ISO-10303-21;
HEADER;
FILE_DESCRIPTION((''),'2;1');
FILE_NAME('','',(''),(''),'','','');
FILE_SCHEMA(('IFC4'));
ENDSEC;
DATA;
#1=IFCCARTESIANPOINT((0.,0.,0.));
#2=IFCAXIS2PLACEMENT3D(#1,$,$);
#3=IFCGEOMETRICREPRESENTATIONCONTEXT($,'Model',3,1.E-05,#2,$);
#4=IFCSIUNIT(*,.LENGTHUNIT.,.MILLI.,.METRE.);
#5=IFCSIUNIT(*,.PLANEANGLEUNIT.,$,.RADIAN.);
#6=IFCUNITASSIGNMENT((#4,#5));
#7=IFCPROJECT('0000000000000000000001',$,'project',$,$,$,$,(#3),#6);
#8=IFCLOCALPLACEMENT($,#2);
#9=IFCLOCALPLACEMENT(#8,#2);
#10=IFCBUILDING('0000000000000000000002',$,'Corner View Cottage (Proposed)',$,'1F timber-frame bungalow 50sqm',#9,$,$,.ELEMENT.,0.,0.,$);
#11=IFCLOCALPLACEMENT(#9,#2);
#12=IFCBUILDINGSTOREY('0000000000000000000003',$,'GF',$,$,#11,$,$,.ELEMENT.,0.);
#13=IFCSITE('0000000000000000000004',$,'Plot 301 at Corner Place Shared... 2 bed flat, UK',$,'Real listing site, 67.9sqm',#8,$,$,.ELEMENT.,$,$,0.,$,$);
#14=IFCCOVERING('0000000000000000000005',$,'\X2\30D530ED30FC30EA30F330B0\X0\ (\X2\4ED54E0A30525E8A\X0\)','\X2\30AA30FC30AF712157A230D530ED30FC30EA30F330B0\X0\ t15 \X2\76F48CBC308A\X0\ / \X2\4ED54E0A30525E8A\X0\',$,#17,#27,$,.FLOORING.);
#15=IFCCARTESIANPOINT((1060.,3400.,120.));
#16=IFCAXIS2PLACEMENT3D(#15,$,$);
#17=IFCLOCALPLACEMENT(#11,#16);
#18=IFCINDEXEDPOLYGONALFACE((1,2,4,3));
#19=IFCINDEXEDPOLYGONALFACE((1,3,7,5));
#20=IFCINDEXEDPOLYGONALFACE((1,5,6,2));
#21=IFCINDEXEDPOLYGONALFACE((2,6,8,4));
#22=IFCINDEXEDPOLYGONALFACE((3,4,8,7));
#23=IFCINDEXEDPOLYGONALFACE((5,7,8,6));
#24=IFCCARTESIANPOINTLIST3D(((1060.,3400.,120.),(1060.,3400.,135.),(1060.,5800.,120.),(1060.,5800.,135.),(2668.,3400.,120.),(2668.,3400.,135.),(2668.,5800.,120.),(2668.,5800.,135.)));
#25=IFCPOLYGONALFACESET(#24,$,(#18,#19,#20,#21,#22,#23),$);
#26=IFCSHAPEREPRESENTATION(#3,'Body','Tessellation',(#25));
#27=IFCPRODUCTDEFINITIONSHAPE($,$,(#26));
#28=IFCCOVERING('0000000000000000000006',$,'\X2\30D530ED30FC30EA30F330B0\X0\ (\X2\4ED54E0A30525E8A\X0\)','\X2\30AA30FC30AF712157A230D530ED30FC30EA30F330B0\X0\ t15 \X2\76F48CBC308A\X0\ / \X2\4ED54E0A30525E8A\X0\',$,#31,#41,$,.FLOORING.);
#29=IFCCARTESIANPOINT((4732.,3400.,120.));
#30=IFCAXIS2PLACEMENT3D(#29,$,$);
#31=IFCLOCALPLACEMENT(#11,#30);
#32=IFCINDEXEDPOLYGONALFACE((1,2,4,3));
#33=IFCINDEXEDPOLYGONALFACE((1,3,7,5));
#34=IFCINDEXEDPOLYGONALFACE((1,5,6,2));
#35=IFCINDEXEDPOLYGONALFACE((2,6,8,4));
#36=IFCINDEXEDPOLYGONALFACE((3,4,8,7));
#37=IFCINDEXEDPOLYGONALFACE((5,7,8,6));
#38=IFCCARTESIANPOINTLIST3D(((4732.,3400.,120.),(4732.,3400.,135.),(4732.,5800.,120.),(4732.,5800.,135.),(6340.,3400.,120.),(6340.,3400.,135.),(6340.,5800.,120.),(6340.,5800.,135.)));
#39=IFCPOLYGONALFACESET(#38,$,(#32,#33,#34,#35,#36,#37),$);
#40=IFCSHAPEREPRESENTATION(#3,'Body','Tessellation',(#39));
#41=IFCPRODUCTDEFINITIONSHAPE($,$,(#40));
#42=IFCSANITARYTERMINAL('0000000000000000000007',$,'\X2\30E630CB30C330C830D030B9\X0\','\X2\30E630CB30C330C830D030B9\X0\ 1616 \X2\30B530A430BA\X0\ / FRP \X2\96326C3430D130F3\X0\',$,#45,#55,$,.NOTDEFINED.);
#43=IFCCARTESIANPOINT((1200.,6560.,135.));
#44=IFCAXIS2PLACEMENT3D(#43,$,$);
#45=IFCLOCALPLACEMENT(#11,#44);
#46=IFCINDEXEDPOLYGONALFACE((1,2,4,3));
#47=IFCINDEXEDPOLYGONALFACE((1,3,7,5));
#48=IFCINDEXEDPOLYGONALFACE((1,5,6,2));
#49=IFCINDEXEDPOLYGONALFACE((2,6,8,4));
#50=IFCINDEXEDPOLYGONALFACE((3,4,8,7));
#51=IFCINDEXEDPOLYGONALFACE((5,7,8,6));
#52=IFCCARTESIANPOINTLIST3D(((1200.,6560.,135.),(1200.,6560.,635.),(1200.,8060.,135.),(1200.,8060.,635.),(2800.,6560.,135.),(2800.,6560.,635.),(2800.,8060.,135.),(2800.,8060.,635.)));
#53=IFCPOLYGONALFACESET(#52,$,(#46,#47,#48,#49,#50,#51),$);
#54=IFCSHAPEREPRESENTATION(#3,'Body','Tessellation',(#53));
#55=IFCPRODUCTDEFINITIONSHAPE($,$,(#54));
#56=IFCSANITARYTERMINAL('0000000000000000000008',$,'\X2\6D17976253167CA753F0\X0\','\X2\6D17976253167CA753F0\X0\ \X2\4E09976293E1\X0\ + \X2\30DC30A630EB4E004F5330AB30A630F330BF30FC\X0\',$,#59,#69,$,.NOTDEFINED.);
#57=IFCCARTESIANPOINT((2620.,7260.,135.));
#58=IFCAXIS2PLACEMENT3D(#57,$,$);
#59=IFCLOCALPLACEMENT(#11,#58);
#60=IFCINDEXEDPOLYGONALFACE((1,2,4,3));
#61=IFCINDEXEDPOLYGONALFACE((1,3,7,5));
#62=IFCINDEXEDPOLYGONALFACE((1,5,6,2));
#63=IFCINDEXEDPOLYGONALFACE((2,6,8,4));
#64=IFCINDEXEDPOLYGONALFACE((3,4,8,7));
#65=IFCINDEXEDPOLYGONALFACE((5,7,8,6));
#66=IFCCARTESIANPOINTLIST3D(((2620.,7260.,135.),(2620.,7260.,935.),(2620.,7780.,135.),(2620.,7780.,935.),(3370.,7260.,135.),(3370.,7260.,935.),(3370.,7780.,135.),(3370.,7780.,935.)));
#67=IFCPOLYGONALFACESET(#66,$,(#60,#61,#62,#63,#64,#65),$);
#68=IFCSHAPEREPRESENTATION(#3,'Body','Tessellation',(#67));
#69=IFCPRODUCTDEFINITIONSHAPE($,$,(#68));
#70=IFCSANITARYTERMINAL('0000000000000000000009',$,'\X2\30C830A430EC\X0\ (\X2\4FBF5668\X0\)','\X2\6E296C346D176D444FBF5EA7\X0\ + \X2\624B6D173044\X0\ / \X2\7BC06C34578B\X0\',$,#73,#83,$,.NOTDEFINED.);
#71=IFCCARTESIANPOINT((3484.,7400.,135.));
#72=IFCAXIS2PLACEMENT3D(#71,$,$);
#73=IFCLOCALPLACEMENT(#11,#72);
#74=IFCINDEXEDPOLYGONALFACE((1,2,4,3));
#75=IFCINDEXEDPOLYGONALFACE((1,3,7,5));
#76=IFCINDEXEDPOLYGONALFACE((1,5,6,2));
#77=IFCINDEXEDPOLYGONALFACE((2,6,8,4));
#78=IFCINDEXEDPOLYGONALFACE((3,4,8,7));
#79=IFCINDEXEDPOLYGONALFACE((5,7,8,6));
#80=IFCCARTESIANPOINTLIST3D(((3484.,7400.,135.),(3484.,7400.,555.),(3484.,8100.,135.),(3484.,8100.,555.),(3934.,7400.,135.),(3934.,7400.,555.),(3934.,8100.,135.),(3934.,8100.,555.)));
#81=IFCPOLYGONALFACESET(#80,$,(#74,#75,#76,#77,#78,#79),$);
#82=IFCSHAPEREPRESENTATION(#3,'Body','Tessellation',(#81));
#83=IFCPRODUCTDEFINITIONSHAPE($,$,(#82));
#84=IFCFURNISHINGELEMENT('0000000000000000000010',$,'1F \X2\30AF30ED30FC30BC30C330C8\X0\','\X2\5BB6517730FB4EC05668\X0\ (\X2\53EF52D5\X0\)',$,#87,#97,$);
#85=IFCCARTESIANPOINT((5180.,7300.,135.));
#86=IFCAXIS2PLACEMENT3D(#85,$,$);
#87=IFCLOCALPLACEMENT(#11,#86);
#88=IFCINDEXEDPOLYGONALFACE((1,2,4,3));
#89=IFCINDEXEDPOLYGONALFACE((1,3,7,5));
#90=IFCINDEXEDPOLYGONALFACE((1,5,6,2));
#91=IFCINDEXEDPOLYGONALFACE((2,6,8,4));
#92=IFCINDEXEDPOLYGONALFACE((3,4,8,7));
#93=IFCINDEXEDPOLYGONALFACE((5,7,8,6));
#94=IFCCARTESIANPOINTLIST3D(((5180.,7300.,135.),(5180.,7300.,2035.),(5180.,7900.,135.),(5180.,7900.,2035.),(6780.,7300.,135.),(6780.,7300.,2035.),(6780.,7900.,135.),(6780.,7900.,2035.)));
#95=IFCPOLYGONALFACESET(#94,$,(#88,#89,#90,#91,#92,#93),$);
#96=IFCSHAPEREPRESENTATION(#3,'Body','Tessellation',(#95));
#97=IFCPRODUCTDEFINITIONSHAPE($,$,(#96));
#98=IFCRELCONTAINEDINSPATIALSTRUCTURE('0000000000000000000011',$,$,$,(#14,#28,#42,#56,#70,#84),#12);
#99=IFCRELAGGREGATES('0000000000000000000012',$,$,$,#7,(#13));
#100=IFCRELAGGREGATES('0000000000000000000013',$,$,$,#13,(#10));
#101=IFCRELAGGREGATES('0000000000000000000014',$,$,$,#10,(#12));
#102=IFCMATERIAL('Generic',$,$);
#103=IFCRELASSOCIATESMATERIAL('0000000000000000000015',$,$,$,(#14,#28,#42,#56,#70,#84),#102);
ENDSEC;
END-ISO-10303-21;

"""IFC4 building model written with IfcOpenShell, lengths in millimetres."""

from ifc_helpers import new_model, si_unit, frame, frame_2d, origin, place, context, project, spatial, rectangle, extrude, material, element, save


model = new_model("IFC4")

# Units and contexts
model_context = context("Model", 3, precision=1e-05, world=origin())
ifc_project = project(units=[si_unit("LENGTHUNIT", "METRE", prefix="MILLI"), si_unit("PLANEANGLEUNIT", "RADIAN")], contexts=[model_context])

# Site, building, storey
site_placement = place(None, origin())
site = spatial("IfcSite", under=ifc_project, at=site_placement, Name="Plot 301 at Corner Place Shared... 2 bed flat, UK", ObjectType="Real listing site, 67.9sqm", CompositionType="ELEMENT", RefElevation=0.0)
building_placement = place(site_placement, origin())
building = spatial("IfcBuilding", under=site, at=building_placement, Name="Corner View Cottage (Proposed)", ObjectType="1F timber-frame bungalow 50sqm", CompositionType="ELEMENT", ElevationOfRefHeight=0.0, ElevationOfTerrain=0.0)
storey_placement = place(building_placement, origin())
storey = spatial("IfcBuildingStorey", under=building, at=storey_placement, Name="GF", CompositionType="ELEMENT", Elevation=0.0)

# Coverings
ifc_material_1 = material(Name="Generic")
covering_1_placement = place(storey_placement, frame((1060.0, 3400.0, 120.0)))
element("IfcCovering", 1, at=covering_1_placement, inside=storey, material=ifc_material_1, Name="フローリング (仕上げ床)", Description="オーク無垢フローリング t15 直貼り / 仕上げ床", PredefinedType="FLOORING", context=model_context, shape_type="SweptSolid", body=[
    extrude(rectangle(XDim=1608.0, YDim=2400.0, at=frame_2d((804.0, 1200.0))), frame((1060.0, 3400.0, 120.0)), (0.0, 0.0, 1.0), 15.0),
])
covering_2_placement = place(storey_placement, frame((4732.0, 3400.0, 120.0)))
element("IfcCovering", 2, at=covering_2_placement, inside=storey, material=ifc_material_1, Name="フローリング (仕上げ床)", Description="オーク無垢フローリング t15 直貼り / 仕上げ床", PredefinedType="FLOORING", context=model_context, shape_type="SweptSolid", body=[
    extrude(rectangle(XDim=1608.0, YDim=2400.0, at=frame_2d((804.0, 1200.0))), frame((4732.0, 3400.0, 120.0)), (0.0, 0.0, 1.0), 15.0),
])

# Sanitary terminals
sanitary_terminal_1_placement = place(storey_placement, frame((1200.0, 6560.0, 135.0)))
element("IfcSanitaryTerminal", 3, at=sanitary_terminal_1_placement, inside=storey, material=ifc_material_1, Name="ユニットバス", Description="ユニットバス 1616 サイズ / FRP 防水パン", PredefinedType="NOTDEFINED", context=model_context, shape_type="SweptSolid", body=[
    extrude(rectangle(XDim=1600.0, YDim=1500.0, at=frame_2d((800.0, 750.0))), frame((1200.0, 6560.0, 135.0)), (0.0, 0.0, 1.0), 500.0),
])
sanitary_terminal_2_placement = place(storey_placement, frame((2620.0, 7260.0, 135.0)))
element("IfcSanitaryTerminal", 4, at=sanitary_terminal_2_placement, inside=storey, material=ifc_material_1, Name="洗面化粧台", Description="洗面化粧台 三面鏡 + ボウル一体カウンター", PredefinedType="NOTDEFINED", context=model_context, shape_type="SweptSolid", body=[
    extrude(rectangle(XDim=750.0, YDim=520.0, at=frame_2d((375.0, 260.0))), frame((2620.0, 7260.0, 135.0)), (0.0, 0.0, 1.0), 800.0),
])
sanitary_terminal_3_placement = place(storey_placement, frame((3484.0, 7400.0, 135.0)))
element("IfcSanitaryTerminal", 5, at=sanitary_terminal_3_placement, inside=storey, material=ifc_material_1, Name="トイレ (便器)", Description="温水洗浄便座 + 手洗い / 節水型", PredefinedType="NOTDEFINED", context=model_context, shape_type="SweptSolid", body=[
    extrude(rectangle(XDim=450.0, YDim=700.0, at=frame_2d((225.0, 350.0))), frame((3484.0, 7400.0, 135.0)), (0.0, 0.0, 1.0), 420.0),
])

# Furnishing element
furnishing_placement = place(storey_placement, frame((5180.0, 7300.0, 135.0)))
element("IfcFurnishingElement", 6, at=furnishing_placement, inside=storey, material=ifc_material_1, Name="1F クローゼット", Description="家具・什器 (可動)", context=model_context, shape_type="SweptSolid", body=[
    extrude(rectangle(XDim=1600.0, YDim=600.0, at=frame_2d((800.0, 300.0))), frame((5180.0, 7300.0, 135.0)), (0.0, 0.0, 1.0), 1900.0),
])

save(model, "model.ifc")
